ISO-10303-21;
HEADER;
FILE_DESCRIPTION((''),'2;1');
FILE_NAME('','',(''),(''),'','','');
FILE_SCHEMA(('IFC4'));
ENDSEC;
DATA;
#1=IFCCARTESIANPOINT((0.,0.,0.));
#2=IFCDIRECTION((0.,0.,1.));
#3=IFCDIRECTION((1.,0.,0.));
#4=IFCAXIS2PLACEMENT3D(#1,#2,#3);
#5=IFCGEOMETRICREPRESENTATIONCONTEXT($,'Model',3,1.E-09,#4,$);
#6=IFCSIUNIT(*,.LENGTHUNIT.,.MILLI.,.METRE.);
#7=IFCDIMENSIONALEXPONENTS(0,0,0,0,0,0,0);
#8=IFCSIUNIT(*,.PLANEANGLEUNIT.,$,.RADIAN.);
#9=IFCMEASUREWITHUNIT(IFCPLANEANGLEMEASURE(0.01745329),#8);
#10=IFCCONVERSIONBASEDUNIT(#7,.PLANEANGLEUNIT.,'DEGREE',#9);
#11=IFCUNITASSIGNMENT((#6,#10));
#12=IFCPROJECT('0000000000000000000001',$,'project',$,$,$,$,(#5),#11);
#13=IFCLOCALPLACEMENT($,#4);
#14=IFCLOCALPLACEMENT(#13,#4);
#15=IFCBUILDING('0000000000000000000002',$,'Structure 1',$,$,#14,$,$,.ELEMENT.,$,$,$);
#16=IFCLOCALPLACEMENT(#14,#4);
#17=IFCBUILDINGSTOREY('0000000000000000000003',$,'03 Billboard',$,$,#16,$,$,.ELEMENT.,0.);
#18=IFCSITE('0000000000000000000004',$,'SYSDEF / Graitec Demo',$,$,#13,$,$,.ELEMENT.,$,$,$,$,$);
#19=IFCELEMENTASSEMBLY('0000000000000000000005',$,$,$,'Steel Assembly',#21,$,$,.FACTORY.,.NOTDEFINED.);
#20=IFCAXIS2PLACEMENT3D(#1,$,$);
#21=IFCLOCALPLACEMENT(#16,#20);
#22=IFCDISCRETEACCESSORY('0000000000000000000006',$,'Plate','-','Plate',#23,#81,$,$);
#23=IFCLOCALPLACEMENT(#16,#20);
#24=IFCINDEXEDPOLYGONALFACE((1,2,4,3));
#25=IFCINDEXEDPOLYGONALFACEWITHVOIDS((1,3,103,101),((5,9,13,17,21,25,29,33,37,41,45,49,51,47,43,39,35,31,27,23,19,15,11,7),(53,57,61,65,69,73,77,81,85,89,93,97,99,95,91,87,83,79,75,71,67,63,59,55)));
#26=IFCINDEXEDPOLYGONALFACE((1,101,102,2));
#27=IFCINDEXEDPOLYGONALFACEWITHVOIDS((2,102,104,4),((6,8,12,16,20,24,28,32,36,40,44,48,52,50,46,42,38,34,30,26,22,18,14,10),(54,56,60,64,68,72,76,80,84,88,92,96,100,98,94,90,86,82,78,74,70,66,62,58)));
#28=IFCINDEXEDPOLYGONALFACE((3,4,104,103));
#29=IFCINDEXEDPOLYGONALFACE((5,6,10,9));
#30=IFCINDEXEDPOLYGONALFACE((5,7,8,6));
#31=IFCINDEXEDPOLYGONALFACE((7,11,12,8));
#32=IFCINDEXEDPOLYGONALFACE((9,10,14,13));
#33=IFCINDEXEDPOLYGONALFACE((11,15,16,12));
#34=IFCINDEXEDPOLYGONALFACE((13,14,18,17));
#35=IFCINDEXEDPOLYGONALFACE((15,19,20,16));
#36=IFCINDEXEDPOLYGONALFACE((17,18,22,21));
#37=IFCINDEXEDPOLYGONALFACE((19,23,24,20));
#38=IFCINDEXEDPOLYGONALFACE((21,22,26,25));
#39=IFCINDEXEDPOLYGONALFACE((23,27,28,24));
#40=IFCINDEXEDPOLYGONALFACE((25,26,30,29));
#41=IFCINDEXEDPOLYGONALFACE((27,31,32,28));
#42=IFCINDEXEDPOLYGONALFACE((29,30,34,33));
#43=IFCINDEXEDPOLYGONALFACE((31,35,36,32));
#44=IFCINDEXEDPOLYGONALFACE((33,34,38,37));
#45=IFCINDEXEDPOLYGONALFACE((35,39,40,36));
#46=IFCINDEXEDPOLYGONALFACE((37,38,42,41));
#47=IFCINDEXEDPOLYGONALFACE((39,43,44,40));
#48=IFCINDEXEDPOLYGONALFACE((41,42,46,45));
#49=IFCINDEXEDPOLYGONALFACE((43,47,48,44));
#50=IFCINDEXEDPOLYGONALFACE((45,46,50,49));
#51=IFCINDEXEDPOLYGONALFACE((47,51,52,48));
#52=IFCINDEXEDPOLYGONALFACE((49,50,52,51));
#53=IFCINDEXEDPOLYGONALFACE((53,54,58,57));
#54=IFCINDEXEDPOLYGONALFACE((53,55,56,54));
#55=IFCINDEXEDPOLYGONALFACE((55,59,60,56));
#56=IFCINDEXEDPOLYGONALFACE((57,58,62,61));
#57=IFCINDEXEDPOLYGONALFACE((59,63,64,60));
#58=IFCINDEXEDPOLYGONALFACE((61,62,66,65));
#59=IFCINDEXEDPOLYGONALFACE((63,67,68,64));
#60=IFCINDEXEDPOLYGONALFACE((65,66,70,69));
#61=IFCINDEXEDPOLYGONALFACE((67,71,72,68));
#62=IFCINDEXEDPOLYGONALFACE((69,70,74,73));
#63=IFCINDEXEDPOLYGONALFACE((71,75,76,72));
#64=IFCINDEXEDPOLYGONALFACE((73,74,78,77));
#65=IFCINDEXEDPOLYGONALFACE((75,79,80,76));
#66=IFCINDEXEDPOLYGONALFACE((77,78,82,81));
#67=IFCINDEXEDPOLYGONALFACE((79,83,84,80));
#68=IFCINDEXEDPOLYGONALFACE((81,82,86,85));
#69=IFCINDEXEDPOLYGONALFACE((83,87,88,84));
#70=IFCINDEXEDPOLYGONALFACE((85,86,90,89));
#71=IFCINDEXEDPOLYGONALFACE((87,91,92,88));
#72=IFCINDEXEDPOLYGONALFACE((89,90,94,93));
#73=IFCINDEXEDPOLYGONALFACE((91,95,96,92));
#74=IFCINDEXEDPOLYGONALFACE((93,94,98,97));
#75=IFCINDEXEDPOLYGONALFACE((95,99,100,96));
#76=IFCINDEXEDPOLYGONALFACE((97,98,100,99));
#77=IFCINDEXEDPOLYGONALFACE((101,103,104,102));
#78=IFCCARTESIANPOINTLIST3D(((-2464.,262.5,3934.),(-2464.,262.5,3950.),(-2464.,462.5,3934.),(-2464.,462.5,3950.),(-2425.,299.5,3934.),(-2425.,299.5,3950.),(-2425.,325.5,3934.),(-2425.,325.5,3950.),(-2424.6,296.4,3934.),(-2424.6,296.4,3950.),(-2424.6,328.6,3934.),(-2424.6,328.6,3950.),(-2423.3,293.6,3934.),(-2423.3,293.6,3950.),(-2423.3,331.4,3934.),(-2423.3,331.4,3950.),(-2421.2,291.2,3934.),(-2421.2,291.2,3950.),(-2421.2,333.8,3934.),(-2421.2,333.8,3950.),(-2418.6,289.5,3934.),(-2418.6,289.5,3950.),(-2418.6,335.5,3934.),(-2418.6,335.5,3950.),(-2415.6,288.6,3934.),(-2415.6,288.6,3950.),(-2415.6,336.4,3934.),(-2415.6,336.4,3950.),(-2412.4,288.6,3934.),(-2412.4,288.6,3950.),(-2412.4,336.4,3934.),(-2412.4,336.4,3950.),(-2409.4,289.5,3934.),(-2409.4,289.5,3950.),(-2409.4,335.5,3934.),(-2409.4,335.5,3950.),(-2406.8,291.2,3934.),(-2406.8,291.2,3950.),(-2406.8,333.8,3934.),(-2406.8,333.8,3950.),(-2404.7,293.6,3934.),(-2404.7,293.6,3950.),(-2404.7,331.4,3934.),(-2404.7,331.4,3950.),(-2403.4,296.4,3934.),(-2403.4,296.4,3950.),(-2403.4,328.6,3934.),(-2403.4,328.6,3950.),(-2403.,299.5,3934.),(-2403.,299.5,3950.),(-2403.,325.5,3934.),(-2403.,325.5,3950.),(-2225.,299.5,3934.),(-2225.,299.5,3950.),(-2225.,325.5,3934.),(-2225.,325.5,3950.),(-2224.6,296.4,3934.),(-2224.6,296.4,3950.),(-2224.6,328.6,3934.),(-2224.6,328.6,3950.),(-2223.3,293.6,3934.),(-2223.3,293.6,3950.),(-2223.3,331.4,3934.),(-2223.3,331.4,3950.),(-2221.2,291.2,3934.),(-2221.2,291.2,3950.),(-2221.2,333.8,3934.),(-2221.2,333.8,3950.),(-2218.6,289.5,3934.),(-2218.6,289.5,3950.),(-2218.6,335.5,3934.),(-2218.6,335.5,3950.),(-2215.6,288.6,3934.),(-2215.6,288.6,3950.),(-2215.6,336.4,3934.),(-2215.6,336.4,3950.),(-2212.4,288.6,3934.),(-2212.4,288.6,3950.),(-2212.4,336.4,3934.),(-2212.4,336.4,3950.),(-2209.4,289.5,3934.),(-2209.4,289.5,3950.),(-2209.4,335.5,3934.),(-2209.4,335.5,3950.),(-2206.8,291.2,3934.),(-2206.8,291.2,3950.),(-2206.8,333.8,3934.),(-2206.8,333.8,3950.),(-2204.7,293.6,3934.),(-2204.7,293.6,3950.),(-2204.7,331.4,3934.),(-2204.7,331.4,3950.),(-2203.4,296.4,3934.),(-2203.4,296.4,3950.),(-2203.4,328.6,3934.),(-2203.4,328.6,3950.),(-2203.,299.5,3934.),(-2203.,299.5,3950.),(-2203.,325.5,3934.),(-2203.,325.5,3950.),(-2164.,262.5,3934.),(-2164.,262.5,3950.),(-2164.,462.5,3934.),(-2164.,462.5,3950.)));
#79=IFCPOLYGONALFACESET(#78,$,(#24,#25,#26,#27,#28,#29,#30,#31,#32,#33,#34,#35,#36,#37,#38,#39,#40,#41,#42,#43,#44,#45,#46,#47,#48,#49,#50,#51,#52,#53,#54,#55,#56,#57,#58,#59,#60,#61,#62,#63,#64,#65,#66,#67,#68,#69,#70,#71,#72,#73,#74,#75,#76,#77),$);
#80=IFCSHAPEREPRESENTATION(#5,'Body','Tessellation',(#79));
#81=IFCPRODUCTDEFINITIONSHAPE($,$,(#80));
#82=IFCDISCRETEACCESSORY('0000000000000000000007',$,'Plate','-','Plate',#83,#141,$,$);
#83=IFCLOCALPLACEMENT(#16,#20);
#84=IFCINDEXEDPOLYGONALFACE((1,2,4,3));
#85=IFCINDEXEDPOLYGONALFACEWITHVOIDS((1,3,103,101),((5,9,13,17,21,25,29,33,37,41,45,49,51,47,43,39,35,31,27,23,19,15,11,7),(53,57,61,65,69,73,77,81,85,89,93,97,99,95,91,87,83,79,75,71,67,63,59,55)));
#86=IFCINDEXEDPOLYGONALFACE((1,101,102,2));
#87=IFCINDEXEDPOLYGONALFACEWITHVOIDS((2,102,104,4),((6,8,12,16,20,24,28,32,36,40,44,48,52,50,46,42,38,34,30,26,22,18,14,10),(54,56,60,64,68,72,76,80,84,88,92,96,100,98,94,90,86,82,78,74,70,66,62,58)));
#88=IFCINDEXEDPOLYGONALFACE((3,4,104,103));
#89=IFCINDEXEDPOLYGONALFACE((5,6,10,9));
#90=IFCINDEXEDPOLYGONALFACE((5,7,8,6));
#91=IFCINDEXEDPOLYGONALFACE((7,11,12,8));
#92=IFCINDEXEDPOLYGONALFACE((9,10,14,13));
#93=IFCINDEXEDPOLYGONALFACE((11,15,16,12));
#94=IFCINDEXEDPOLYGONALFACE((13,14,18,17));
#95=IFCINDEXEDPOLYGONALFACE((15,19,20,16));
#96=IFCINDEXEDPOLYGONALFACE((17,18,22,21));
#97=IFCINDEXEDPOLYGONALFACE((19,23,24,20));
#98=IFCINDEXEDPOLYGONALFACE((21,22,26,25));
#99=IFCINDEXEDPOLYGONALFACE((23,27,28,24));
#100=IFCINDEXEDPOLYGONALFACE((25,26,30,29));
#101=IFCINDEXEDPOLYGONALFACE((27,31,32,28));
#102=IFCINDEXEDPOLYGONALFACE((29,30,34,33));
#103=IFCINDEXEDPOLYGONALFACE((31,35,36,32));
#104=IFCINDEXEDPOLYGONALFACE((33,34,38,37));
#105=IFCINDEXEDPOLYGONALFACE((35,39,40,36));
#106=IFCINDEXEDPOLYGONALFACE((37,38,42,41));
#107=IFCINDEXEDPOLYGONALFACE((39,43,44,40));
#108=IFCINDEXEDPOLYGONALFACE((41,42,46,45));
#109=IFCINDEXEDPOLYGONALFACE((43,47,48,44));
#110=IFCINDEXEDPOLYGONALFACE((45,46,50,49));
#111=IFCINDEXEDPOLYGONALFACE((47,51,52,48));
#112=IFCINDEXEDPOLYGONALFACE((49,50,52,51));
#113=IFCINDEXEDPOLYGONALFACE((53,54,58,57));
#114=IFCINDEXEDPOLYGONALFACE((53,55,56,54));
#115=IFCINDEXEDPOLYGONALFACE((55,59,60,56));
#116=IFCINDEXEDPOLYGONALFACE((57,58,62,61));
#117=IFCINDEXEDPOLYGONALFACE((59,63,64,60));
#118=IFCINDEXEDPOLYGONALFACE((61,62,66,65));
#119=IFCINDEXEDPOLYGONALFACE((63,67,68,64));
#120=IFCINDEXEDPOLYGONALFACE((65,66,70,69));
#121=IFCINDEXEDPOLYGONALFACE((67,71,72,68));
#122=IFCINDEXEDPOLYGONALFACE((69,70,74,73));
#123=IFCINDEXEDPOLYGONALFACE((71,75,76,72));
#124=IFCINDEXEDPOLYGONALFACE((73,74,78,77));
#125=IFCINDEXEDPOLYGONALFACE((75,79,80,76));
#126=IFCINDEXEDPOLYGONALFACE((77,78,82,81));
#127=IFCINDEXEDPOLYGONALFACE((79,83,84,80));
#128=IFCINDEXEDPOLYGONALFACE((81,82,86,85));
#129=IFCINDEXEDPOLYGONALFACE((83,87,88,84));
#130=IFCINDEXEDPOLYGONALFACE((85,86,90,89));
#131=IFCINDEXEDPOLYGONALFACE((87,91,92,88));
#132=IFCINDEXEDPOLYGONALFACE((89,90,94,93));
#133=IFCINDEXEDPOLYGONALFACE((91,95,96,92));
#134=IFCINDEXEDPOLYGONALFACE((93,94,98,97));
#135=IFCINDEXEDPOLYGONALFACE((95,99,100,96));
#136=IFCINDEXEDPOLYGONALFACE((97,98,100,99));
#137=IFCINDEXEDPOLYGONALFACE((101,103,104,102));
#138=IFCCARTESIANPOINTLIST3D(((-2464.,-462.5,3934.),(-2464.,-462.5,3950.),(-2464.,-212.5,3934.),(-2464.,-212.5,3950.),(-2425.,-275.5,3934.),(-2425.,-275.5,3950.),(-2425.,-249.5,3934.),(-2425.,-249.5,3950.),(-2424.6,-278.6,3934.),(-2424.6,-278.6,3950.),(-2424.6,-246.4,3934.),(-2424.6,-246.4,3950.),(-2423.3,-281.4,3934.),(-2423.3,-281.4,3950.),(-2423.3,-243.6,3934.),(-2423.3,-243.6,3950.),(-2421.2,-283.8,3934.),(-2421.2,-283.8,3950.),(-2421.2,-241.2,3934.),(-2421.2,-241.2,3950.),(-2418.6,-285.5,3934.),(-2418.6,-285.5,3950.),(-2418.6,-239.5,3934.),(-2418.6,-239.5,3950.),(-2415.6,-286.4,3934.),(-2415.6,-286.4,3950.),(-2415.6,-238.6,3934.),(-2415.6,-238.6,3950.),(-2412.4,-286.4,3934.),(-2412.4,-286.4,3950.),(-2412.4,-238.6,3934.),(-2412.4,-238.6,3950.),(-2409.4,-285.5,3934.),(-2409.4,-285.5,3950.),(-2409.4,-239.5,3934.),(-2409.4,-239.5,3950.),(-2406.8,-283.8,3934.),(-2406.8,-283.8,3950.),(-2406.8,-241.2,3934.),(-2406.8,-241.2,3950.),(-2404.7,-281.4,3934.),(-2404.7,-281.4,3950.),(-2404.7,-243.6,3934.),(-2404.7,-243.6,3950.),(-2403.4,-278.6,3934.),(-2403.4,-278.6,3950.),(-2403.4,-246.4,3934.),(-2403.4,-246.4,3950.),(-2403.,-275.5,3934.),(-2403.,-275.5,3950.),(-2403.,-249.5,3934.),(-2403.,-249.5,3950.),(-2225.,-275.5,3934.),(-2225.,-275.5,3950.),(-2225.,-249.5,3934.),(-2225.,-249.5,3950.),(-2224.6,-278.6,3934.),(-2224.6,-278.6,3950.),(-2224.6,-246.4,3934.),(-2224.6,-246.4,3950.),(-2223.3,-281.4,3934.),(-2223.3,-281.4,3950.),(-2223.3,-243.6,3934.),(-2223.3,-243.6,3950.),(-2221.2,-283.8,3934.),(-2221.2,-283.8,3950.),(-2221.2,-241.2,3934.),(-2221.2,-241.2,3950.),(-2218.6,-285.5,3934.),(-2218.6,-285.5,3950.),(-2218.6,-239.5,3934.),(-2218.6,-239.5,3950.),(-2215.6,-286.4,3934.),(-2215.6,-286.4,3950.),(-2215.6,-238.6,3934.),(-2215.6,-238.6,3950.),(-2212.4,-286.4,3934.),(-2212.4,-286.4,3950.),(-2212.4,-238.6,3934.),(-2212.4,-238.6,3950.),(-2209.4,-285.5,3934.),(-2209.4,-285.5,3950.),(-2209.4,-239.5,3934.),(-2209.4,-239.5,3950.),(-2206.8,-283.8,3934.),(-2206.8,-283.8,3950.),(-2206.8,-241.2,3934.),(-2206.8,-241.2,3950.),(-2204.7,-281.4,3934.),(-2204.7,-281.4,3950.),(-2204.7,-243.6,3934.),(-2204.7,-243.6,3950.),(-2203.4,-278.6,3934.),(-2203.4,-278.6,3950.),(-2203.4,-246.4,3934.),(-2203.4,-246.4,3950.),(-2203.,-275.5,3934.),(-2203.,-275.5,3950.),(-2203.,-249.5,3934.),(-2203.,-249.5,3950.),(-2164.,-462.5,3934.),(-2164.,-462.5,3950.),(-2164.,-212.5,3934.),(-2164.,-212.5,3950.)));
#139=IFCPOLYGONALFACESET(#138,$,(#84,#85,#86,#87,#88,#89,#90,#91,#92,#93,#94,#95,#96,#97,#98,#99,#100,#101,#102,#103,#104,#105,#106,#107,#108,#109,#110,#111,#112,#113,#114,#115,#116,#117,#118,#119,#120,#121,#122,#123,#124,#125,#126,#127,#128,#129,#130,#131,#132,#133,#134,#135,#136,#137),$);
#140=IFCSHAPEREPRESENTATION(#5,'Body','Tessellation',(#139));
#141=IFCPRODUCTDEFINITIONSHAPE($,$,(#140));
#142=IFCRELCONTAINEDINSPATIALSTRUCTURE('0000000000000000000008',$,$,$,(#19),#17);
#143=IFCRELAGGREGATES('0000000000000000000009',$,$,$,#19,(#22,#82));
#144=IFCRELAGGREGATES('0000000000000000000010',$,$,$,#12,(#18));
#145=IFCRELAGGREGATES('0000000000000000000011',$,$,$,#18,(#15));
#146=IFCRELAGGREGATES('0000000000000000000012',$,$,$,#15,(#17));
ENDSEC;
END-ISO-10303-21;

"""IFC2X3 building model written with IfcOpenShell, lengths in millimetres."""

from ifc_helpers import new_model, entity, si_unit, converted_unit, point, frame, frame_2d, origin, origin_with_axes, place, context, project, spatial, polyline, circle_curve, line_curve, trimmed, segment, composite_curve, outline, extrude, element, aggregate, save


model = new_model("IFC2X3")

# Units and contexts
model_context = context("Model", 3, precision=1e-09, world=origin_with_axes())
ifc_project = project(units=[si_unit("LENGTHUNIT", "METRE", prefix="MILLI"), converted_unit("PLANEANGLEUNIT", "DEGREE", entity("IfcPlaneAngleMeasure", 0.01745329), si_unit("PLANEANGLEUNIT", "RADIAN"), dimensions=[0, 0, 0, 0, 0, 0, 0])], contexts=[model_context])

# Site, building, storey
site_placement = place(None, origin_with_axes())
site = spatial("IfcSite", under=ifc_project, at=site_placement, Name="SYSDEF / Graitec Demo", CompositionType="ELEMENT")
building_placement = place(site_placement, origin_with_axes())
building = spatial("IfcBuilding", under=site, at=building_placement, Name="Structure 1", CompositionType="ELEMENT")
storey_placement = place(building_placement, origin_with_axes())
storey = spatial("IfcBuildingStorey", under=building, at=storey_placement, Name="03 Billboard", CompositionType="ELEMENT", Elevation=0.0)

# Element assembly
assembly_1_placement = place(None, frame((-4406.3, 0.0, 3558.0), z_axis=(-1.0, 0.0, 0.0), x_axis=(0.0, -1.0, 0.0)))
assembly_1 = element("IfcElementAssembly", 1, at=assembly_1_placement, inside=storey, ObjectType="Steel Assembly", AssemblyPlace="FACTORY", PredefinedType="NOTDEFINED")

# Discrete accessories, openings
discrete_accessory_1_placement = place(assembly_1_placement, frame((-462.5, 392.0, -2242.3), z_axis=(0.0, -1.0, 0.0), x_axis=(1.0, 0.0, 0.0)))
discrete_accessory_1 = element("IfcDiscreteAccessory", 2, at=discrete_accessory_1_placement, Name="Plate", Description="-", ObjectType="Plate", context=model_context, shape_type="SweptSolid", body=[
    extrude(outline(polyline([(0.0, 0.0), (200.0, 0.0), (200.0, 300.0), (0.0, 300.0), (0.0, 0.0)])), origin_with_axes(), (0.0, 0.0, 1.0), 16.0),
])
opening_1_placement = place(discrete_accessory_1_placement, frame((150.0, 150.0, -0.5), z_axis=(0.0, 0.0, 1.0), x_axis=(0.0, 1.0, 0.0)))
element("IfcOpeningElement", 3, at=opening_1_placement, cuts=discrete_accessory_1, ObjectType="Opening", context=model_context, shape_type="SweptSolid", body=[
    extrude(outline(composite_curve([segment(trimmed(line_curve((111.0, -13.0), (0.0, 1.0), 26.0), [point((111.0, -13.0))], [point((111.0, 13.0))], True, "CARTESIAN"), True, "CONTINUOUS"), segment(trimmed(circle_curve(frame_2d((100.0, 13.0), x_axis=(1.0, 0.0)), 11.0), [point((111.0, 13.0))], [point((89.0, 13.0))], True, "CARTESIAN"), True, "CONTINUOUS"), segment(trimmed(line_curve((89.0, 13.0), (0.0, -1.0), 26.0), [point((89.0, 13.0))], [point((89.0, -13.0))], True, "CARTESIAN"), True, "CONTINUOUS"), segment(trimmed(circle_curve(frame_2d((100.0, -13.0), x_axis=(1.0, 0.0)), 11.0), [point((89.0, -13.0))], [point((111.0, -13.0))], True, "CARTESIAN"), True, "CONTINUOUS")], self_intersect=False)), origin(), (0.0, 0.0, 1.0), 17.0),
])
opening_2_placement = place(discrete_accessory_1_placement, frame((150.0, 150.0, -0.5), z_axis=(0.0, 0.0, 1.0), x_axis=(0.0, 1.0, 0.0)))
element("IfcOpeningElement", 4, at=opening_2_placement, cuts=discrete_accessory_1, ObjectType="Opening", context=model_context, shape_type="SweptSolid", body=[
    extrude(outline(composite_curve([segment(trimmed(line_curve((-89.0, -13.0), (0.0, 1.0), 26.0), [point((-89.0, -13.0))], [point((-89.0, 13.0))], True, "CARTESIAN"), True, "CONTINUOUS"), segment(trimmed(circle_curve(frame_2d((-100.0, 13.0), x_axis=(1.0, 0.0)), 11.0), [point((-89.0, 13.0))], [point((-111.0, 13.0))], True, "CARTESIAN"), True, "CONTINUOUS"), segment(trimmed(line_curve((-111.0, 13.0), (0.0, -1.0), 26.0), [point((-111.0, 13.0))], [point((-111.0, -13.0))], True, "CARTESIAN"), True, "CONTINUOUS"), segment(trimmed(circle_curve(frame_2d((-100.0, -13.0), x_axis=(1.0, 0.0)), 11.0), [point((-111.0, -13.0))], [point((-89.0, -13.0))], True, "CARTESIAN"), True, "CONTINUOUS")], self_intersect=False)), origin(), (0.0, 0.0, 1.0), 17.0),
])
discrete_accessory_2_placement = place(assembly_1_placement, frame((212.5, 392.0, -2242.3), z_axis=(0.0, -1.0, 0.0), x_axis=(1.0, 0.0, 0.0)))
discrete_accessory_2 = element("IfcDiscreteAccessory", 5, at=discrete_accessory_2_placement, Name="Plate", Description="-", ObjectType="Plate", context=model_context, shape_type="SweptSolid", body=[
    extrude(outline(polyline([(0.0, 0.0), (250.0, 0.0), (250.0, 300.0), (0.0, 300.0), (0.0, 0.0)])), origin_with_axes(), (0.0, 0.0, 1.0), 16.0),
])
opening_3_placement = place(discrete_accessory_2_placement, frame((50.0, 150.0, -0.5), z_axis=(0.0, 0.0, 1.0), x_axis=(0.0, 1.0, 0.0)))
element("IfcOpeningElement", 6, at=opening_3_placement, cuts=discrete_accessory_2, ObjectType="Opening", context=model_context, shape_type="SweptSolid", body=[
    extrude(outline(composite_curve([segment(trimmed(line_curve((111.0, -13.0), (0.0, 1.0), 26.0), [point((111.0, -13.0))], [point((111.0, 13.0))], True, "CARTESIAN"), True, "CONTINUOUS"), segment(trimmed(circle_curve(frame_2d((100.0, 13.0), x_axis=(1.0, 0.0)), 11.0), [point((111.0, 13.0))], [point((89.0, 13.0))], True, "CARTESIAN"), True, "CONTINUOUS"), segment(trimmed(line_curve((89.0, 13.0), (0.0, -1.0), 26.0), [point((89.0, 13.0))], [point((89.0, -13.0))], True, "CARTESIAN"), True, "CONTINUOUS"), segment(trimmed(circle_curve(frame_2d((100.0, -13.0), x_axis=(1.0, 0.0)), 11.0), [point((89.0, -13.0))], [point((111.0, -13.0))], True, "CARTESIAN"), True, "CONTINUOUS")], self_intersect=False)), origin(), (0.0, 0.0, 1.0), 17.0),
])
opening_4_placement = place(discrete_accessory_2_placement, frame((50.0, 150.0, -0.5), z_axis=(0.0, 0.0, 1.0), x_axis=(0.0, 1.0, 0.0)))
element("IfcOpeningElement", 7, at=opening_4_placement, cuts=discrete_accessory_2, ObjectType="Opening", context=model_context, shape_type="SweptSolid", body=[
    extrude(outline(composite_curve([segment(trimmed(line_curve((-89.0, -13.0), (0.0, 1.0), 26.0), [point((-89.0, -13.0))], [point((-89.0, 13.0))], True, "CARTESIAN"), True, "CONTINUOUS"), segment(trimmed(circle_curve(frame_2d((-100.0, 13.0), x_axis=(1.0, 0.0)), 11.0), [point((-89.0, 13.0))], [point((-111.0, 13.0))], True, "CARTESIAN"), True, "CONTINUOUS"), segment(trimmed(line_curve((-111.0, 13.0), (0.0, -1.0), 26.0), [point((-111.0, 13.0))], [point((-111.0, -13.0))], True, "CARTESIAN"), True, "CONTINUOUS"), segment(trimmed(circle_curve(frame_2d((-100.0, -13.0), x_axis=(1.0, 0.0)), 11.0), [point((-111.0, -13.0))], [point((-89.0, -13.0))], True, "CARTESIAN"), True, "CONTINUOUS")], self_intersect=False)), origin(), (0.0, 0.0, 1.0), 17.0),
])
aggregate(assembly_1, [discrete_accessory_1, discrete_accessory_2])

save(model, "model.ifc")
